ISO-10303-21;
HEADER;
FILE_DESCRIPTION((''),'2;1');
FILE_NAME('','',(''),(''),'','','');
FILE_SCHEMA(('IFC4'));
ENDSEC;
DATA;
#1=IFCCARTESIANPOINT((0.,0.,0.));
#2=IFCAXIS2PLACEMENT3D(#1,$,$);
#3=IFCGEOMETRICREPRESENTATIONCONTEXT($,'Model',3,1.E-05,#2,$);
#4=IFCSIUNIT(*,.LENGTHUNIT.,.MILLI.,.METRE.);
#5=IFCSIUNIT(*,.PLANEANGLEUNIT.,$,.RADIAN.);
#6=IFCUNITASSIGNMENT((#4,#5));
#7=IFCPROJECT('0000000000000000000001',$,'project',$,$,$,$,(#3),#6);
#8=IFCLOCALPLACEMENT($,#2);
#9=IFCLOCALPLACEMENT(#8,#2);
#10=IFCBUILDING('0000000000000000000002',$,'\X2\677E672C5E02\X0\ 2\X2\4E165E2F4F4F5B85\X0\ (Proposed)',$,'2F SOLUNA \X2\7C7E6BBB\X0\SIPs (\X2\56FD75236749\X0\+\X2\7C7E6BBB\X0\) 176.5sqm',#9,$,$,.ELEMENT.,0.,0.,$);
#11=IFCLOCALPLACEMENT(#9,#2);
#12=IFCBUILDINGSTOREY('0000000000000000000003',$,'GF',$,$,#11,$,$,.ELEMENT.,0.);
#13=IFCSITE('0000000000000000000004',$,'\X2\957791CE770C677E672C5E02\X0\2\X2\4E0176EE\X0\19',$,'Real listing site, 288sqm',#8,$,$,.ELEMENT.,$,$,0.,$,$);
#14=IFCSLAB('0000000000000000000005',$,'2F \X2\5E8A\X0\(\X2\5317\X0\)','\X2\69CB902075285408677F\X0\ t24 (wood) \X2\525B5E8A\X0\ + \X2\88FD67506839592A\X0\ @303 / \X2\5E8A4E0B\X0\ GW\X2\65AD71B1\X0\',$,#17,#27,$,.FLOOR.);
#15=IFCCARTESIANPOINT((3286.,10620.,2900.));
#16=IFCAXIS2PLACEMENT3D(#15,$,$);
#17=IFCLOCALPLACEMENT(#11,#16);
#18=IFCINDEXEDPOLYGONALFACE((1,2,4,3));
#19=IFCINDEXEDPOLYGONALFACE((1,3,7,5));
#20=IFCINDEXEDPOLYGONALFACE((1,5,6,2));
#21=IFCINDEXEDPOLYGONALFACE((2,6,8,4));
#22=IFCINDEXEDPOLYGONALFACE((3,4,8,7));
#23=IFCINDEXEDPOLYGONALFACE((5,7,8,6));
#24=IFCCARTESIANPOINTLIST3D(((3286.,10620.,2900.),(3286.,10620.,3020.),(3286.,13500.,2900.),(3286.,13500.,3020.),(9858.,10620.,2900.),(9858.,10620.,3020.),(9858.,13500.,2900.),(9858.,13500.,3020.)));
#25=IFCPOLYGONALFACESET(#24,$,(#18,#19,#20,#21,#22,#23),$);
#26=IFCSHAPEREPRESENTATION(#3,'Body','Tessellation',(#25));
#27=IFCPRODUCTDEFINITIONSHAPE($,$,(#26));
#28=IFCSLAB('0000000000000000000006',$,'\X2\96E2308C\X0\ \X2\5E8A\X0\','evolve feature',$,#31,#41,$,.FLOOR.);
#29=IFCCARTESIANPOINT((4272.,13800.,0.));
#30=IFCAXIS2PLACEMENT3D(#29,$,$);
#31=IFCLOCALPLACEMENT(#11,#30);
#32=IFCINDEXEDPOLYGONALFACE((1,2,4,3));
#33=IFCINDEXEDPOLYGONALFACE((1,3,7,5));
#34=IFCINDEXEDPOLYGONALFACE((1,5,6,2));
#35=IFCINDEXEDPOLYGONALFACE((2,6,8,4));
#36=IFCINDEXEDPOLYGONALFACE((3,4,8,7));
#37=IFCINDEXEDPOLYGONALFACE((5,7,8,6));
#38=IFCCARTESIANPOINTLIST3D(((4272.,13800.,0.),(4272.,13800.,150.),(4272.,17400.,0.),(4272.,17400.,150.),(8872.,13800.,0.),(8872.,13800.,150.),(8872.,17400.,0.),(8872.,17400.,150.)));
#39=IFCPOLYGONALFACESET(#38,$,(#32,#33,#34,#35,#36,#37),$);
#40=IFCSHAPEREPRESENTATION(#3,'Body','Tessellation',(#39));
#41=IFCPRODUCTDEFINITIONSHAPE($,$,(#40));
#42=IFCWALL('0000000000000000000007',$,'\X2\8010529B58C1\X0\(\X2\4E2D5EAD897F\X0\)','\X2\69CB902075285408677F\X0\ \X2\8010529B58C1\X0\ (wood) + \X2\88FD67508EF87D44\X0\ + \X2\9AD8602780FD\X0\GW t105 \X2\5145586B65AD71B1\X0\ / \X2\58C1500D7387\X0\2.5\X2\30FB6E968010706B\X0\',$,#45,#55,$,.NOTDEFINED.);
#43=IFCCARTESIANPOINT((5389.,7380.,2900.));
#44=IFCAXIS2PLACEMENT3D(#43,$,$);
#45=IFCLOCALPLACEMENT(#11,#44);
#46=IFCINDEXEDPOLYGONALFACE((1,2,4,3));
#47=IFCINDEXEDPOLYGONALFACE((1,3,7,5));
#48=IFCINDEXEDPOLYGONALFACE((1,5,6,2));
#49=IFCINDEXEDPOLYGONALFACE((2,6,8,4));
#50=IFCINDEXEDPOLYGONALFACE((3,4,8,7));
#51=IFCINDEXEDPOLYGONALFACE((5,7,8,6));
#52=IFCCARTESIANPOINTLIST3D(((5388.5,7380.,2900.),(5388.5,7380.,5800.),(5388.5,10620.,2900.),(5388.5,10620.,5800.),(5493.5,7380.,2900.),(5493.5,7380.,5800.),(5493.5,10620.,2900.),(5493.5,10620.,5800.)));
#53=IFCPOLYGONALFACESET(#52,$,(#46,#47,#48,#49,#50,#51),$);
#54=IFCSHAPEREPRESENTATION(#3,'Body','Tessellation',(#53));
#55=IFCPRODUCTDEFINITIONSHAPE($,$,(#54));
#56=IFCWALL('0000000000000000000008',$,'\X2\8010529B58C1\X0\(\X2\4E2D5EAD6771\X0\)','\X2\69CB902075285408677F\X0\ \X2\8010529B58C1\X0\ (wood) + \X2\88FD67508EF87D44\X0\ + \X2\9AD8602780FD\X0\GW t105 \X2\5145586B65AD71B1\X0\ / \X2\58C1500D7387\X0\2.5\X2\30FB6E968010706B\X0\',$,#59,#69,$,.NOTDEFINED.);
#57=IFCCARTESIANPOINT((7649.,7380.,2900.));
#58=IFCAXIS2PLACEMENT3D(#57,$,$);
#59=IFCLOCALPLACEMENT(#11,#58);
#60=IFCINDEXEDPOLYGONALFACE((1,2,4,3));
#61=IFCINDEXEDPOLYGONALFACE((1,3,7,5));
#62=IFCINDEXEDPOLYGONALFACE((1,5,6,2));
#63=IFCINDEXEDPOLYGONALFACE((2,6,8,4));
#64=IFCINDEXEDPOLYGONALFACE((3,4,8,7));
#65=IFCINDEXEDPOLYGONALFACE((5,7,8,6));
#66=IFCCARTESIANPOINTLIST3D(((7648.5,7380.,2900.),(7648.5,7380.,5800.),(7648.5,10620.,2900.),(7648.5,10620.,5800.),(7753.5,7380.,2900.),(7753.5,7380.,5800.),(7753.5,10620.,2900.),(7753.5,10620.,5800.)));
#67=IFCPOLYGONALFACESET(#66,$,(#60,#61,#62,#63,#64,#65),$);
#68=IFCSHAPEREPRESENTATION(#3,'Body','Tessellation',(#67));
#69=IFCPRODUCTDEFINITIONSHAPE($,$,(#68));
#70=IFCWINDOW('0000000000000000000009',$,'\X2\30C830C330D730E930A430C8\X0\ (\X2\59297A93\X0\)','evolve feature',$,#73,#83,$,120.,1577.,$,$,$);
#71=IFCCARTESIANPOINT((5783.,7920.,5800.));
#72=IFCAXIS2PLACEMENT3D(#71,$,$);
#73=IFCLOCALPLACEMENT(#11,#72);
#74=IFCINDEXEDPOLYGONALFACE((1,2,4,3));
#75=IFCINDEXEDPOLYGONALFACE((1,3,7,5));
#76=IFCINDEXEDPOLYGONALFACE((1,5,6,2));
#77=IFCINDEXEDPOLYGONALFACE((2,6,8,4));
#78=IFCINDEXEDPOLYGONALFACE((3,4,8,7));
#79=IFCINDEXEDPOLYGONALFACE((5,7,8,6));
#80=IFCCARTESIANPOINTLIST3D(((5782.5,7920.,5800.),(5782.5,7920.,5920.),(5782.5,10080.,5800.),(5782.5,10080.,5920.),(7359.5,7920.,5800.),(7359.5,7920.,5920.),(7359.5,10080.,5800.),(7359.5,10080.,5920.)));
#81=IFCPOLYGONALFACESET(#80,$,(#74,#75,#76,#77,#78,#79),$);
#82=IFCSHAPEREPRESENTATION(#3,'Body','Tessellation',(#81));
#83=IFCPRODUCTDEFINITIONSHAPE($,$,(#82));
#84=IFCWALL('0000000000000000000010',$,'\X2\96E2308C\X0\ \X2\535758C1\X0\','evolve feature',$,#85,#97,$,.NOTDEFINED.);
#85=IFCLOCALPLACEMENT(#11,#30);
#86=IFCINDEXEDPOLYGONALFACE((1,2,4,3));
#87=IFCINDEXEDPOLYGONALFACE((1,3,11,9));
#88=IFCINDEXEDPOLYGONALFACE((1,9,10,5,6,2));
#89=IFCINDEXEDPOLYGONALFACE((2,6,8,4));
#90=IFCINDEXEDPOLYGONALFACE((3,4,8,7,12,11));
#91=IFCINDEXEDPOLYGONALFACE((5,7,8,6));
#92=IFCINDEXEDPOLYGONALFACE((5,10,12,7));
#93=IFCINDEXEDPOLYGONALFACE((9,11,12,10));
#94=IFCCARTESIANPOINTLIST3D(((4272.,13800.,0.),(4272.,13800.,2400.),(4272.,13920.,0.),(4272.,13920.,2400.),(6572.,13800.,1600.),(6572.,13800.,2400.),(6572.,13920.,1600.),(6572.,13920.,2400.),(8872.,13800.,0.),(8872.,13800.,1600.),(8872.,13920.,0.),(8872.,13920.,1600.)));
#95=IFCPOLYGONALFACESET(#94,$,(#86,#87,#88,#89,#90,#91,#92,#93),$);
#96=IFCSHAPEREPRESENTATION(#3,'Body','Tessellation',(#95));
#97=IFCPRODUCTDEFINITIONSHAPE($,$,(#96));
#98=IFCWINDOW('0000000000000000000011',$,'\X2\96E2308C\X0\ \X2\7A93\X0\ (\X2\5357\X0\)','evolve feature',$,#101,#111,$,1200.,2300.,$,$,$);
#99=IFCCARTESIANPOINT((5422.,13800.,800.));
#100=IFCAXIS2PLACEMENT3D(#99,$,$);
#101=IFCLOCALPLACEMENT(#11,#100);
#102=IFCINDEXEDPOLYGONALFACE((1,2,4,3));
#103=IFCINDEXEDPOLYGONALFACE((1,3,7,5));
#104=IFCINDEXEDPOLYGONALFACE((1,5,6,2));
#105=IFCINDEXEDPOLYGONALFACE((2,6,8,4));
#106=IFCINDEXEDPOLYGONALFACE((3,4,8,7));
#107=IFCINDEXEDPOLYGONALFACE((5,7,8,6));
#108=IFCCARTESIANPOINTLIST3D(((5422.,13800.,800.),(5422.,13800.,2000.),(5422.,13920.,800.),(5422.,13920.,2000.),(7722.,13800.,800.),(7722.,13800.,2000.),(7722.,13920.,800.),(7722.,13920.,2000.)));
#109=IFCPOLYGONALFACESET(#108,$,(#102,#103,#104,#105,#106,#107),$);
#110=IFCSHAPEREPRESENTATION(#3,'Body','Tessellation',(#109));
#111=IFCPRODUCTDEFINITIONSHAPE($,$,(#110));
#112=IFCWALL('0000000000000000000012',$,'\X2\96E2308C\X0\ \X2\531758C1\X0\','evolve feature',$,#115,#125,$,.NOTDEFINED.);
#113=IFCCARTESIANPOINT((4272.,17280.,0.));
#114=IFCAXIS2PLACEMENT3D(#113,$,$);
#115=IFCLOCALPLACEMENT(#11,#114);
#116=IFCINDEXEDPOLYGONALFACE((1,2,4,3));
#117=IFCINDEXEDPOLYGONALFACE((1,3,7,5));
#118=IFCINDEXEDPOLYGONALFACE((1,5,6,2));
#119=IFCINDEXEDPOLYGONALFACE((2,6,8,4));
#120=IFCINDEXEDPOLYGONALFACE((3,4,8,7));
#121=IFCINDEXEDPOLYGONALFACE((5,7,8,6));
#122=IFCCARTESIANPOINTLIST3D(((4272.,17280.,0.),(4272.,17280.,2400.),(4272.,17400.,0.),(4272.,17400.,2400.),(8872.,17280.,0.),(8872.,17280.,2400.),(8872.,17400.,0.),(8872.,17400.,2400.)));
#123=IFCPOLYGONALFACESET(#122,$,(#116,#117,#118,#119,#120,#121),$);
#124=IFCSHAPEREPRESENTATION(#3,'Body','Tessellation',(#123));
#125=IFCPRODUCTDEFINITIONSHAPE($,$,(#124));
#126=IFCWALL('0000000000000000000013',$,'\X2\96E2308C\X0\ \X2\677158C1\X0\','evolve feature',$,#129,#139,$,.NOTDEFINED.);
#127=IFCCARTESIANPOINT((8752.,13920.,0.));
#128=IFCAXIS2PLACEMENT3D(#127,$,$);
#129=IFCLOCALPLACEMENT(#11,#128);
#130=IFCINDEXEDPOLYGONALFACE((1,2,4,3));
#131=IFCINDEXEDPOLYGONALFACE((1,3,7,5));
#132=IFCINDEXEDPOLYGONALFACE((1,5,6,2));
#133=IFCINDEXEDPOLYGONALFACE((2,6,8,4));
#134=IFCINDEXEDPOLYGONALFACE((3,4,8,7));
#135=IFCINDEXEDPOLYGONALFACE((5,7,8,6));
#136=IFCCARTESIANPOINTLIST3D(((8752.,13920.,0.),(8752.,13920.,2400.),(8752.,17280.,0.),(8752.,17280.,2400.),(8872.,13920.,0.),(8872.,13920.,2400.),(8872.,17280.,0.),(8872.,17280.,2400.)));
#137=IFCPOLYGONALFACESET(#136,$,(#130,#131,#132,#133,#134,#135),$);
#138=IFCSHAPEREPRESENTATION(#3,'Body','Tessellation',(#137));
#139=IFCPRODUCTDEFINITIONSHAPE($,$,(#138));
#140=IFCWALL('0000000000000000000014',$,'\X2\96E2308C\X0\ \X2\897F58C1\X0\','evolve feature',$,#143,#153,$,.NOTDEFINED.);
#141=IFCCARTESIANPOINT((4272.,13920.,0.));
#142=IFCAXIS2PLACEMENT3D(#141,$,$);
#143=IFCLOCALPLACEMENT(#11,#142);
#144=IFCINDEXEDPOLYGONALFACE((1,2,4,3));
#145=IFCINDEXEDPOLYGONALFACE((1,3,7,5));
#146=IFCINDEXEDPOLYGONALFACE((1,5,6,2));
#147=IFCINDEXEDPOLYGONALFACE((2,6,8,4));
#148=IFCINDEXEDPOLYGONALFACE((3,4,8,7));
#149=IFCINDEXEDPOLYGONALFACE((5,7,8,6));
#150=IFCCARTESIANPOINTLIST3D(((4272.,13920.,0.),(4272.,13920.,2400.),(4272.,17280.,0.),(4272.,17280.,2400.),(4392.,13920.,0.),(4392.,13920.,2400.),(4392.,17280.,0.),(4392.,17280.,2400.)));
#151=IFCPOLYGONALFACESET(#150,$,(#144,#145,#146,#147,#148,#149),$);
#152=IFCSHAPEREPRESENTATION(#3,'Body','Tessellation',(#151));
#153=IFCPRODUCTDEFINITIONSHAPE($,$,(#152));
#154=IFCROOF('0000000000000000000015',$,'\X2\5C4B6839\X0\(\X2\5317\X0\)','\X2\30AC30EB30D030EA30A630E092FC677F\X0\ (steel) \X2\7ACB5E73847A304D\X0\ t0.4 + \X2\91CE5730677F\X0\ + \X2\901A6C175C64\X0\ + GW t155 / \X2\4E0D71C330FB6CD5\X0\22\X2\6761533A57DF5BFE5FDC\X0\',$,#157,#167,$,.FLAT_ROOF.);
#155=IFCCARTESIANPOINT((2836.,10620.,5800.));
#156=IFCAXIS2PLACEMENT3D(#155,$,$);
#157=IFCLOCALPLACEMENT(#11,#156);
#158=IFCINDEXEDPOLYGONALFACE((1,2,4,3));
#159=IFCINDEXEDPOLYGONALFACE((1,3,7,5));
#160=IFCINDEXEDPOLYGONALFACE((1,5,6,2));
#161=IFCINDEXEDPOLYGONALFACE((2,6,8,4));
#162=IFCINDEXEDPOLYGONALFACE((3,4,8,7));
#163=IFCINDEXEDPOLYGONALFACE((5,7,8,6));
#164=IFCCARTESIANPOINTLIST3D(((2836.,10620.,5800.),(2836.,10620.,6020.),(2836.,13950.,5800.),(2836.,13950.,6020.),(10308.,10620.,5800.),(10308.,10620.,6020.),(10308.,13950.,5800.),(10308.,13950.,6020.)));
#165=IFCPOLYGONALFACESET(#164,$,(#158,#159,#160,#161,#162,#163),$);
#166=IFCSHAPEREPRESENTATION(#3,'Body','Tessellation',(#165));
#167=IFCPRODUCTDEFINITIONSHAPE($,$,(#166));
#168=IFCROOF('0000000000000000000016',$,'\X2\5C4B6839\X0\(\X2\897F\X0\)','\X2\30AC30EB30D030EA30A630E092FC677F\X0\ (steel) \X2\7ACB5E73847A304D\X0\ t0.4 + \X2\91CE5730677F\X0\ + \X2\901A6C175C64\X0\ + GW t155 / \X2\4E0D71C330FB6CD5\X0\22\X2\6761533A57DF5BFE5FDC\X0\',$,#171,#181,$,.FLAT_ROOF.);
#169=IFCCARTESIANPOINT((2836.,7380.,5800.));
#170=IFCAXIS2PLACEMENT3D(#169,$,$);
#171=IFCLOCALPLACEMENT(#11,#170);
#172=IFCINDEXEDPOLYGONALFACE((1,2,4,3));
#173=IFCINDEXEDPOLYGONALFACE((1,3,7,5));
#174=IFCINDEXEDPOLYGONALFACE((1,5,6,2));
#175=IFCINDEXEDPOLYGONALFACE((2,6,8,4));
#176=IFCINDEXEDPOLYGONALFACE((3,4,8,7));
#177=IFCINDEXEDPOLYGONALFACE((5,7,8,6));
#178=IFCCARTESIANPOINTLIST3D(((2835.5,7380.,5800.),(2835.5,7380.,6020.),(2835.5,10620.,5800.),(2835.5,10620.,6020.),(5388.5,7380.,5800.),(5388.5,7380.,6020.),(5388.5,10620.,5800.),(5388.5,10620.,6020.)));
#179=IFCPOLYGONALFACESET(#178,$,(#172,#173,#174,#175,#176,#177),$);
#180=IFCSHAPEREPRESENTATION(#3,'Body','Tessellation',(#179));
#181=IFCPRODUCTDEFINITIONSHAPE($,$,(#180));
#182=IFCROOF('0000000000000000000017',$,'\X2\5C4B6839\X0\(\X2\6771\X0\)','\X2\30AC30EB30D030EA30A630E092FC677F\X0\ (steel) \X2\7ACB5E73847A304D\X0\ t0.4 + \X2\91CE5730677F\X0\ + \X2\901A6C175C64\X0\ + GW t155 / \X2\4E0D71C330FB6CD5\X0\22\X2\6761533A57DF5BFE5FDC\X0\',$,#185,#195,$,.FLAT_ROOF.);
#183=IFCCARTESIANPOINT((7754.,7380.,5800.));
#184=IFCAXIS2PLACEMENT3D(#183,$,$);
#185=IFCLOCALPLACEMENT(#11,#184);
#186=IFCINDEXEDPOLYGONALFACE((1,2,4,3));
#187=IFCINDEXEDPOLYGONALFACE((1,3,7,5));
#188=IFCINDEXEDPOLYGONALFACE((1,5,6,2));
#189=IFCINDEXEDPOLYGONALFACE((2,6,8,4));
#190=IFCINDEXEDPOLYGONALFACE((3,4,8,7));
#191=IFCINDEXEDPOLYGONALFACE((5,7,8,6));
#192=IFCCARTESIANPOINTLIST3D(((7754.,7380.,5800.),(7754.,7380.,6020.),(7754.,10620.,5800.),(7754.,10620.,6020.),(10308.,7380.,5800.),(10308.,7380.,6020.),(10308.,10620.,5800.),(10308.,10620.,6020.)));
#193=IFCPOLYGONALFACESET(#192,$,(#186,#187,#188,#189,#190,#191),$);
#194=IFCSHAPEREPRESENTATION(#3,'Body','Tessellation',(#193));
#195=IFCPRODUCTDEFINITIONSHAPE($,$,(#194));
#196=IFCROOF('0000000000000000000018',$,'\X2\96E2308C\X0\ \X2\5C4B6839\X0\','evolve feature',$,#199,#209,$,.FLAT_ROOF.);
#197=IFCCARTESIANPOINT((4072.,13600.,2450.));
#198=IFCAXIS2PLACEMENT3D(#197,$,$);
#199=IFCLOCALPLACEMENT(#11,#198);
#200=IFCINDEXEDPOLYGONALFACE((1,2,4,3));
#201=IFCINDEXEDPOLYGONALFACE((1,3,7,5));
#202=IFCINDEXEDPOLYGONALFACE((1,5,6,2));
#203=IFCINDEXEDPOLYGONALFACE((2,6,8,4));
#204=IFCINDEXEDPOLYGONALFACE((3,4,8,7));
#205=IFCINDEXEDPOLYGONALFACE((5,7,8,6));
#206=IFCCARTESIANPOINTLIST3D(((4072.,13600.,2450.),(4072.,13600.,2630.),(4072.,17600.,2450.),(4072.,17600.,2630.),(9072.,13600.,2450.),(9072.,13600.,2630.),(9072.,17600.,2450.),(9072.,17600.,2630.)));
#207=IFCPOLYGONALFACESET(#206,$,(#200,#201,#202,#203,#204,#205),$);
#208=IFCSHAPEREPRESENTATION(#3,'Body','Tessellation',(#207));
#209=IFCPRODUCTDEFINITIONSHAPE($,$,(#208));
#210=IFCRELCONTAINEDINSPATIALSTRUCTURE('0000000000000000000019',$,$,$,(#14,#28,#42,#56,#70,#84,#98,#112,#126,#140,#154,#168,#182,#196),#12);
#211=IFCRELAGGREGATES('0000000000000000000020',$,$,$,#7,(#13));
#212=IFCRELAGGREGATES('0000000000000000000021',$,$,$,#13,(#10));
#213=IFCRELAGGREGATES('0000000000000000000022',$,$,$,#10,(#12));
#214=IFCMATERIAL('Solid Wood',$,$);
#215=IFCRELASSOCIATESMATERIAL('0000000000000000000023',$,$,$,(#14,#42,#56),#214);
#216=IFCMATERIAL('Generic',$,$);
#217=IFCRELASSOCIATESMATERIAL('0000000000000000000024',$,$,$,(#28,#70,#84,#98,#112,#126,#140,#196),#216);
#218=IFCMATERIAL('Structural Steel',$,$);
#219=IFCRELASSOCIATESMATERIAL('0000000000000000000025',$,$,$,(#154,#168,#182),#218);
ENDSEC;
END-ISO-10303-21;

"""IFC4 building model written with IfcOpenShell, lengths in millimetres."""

from ifc_helpers import new_model, si_unit, frame, frame_2d, origin, place, context, project, spatial, rectangle, extrude, material, element, fill, save


model = new_model("IFC4")

# Units and contexts
model_context = context("Model", 3, precision=1e-05, world=origin())
ifc_project = project(units=[si_unit("LENGTHUNIT", "METRE", prefix="MILLI"), si_unit("PLANEANGLEUNIT", "RADIAN")], contexts=[model_context])

# Site, building, storey
site_placement = place(None, origin())
site = spatial("IfcSite", under=ifc_project, at=site_placement, Name="長野県松本市2丁目19", ObjectType="Real listing site, 288sqm", CompositionType="ELEMENT", RefElevation=0.0)
building_placement = place(site_placement, origin())
building = spatial("IfcBuilding", under=site, at=building_placement, Name="松本市 2世帯住宅 (Proposed)", ObjectType="2F SOLUNA 籾殻SIPs (国産杉+籾殻) 176.5sqm", CompositionType="ELEMENT", ElevationOfRefHeight=0.0, ElevationOfTerrain=0.0)
storey_placement = place(building_placement, origin())
storey = spatial("IfcBuildingStorey", under=building, at=storey_placement, Name="GF", CompositionType="ELEMENT", Elevation=0.0)

# Slabs
ifc_material_1 = material(Name="Solid Wood")
slab_1_placement = place(storey_placement, frame((3286.0, 10620.0, 2900.0)))
element("IfcSlab", 1, at=slab_1_placement, inside=storey, material=ifc_material_1, Name="2F 床(北)", Description="構造用合板 t24 (wood) 剛床 + 製材根太 @303 / 床下 GW断熱", PredefinedType="FLOOR", context=model_context, shape_type="SweptSolid", body=[
    extrude(rectangle(XDim=6572.0, YDim=2880.0, at=frame_2d((3286.0, 1440.0))), frame((3286.0, 10620.0, 2900.0)), (0.0, 0.0, 1.0), 120.0),
])
ifc_material_2 = material(Name="Generic")
slab_2_placement = place(storey_placement, frame((4272.0, 13800.0, 0.0)))
element("IfcSlab", 2, at=slab_2_placement, inside=storey, material=ifc_material_2, Name="離れ 床", Description="evolve feature", PredefinedType="FLOOR", context=model_context, shape_type="SweptSolid", body=[
    extrude(rectangle(XDim=4600.0, YDim=3600.0, at=frame_2d((2300.0, 1800.0))), frame((4272.0, 13800.0, 0.0)), (0.0, 0.0, 1.0), 150.0),
])

# Walls
wall_1_placement = place(storey_placement, frame((5389.0, 7380.0, 2900.0)))
element("IfcWall", 3, at=wall_1_placement, inside=storey, material=ifc_material_1, Name="耐力壁(中庭西)", Description="構造用合板 耐力壁 (wood) + 製材軸組 + 高性能GW t105 充填断熱 / 壁倍率2.5・準耐火", PredefinedType="NOTDEFINED", context=model_context, shape_type="SweptSolid", body=[
    extrude(rectangle(XDim=105.0, YDim=3240.0, at=frame_2d((52.0, 1620.0))), frame((5389.0, 7380.0, 2900.0)), (0.0, 0.0, 1.0), 2900.0),
])
wall_2_placement = place(storey_placement, frame((7649.0, 7380.0, 2900.0)))
element("IfcWall", 4, at=wall_2_placement, inside=storey, material=ifc_material_1, Name="耐力壁(中庭東)", Description="構造用合板 耐力壁 (wood) + 製材軸組 + 高性能GW t105 充填断熱 / 壁倍率2.5・準耐火", PredefinedType="NOTDEFINED", context=model_context, shape_type="SweptSolid", body=[
    extrude(rectangle(XDim=105.0, YDim=3240.0, at=frame_2d((52.0, 1620.0))), frame((7649.0, 7380.0, 2900.0)), (0.0, 0.0, 1.0), 2900.0),
])

# Window
window_1_placement = place(storey_placement, frame((5783.0, 7920.0, 5800.0)))
element("IfcWindow", 5, at=window_1_placement, inside=storey, material=ifc_material_2, Name="トップライト (天窓)", Description="evolve feature", OverallHeight=120.0, OverallWidth=1577.0, context=model_context, shape_type="SweptSolid", body=[
    extrude(rectangle(XDim=1577.0, YDim=2160.0, at=frame_2d((788.0, 1080.0))), frame((5783.0, 7920.0, 5800.0)), (0.0, 0.0, 1.0), 120.0),
])

# Wall, opening, window
wall_3_placement = place(storey_placement, frame((4272.0, 13800.0, 0.0)))
wall_3 = element("IfcWall", 6, at=wall_3_placement, inside=storey, material=ifc_material_2, Name="離れ 南壁", Description="evolve feature", PredefinedType="NOTDEFINED", context=model_context, shape_type="SweptSolid", body=[
    extrude(rectangle(XDim=4600.0, YDim=120.0, at=frame_2d((2300.0, 60.0))), frame((4272.0, 13800.0, 0.0)), (0.0, 0.0, 1.0), 2400.0),
])
opening_1_placement = place(storey_placement, frame((5422.0, 13800.0, 800.0)))
opening_1 = element("IfcOpeningElement", 7, at=opening_1_placement, cuts=wall_3, PredefinedType="NOTDEFINED", context=model_context, shape_type="SweptSolid", body=[
    extrude(rectangle(XDim=2300.0, YDim=120.0, at=frame_2d((1150.0, 60.0))), frame((5422.0, 13800.0, 800.0)), (0.0, 0.0, 1.0), 1200.0),
])
window_2_placement = place(storey_placement, frame((5422.0, 13800.0, 800.0)))
window_2 = element("IfcWindow", 8, at=window_2_placement, inside=storey, material=ifc_material_2, Name="離れ 窓 (南)", Description="evolve feature", OverallHeight=1200.0, OverallWidth=2300.0, context=model_context, shape_type="SweptSolid", body=[
    extrude(rectangle(XDim=2300.0, YDim=120.0, at=frame_2d((1150.0, 60.0))), frame((5422.0, 13800.0, 800.0)), (0.0, 0.0, 1.0), 1200.0),
])
fill(opening_1, window_2)

# Walls
wall_4_placement = place(storey_placement, frame((4272.0, 17280.0, 0.0)))
element("IfcWall", 9, at=wall_4_placement, inside=storey, material=ifc_material_2, Name="離れ 北壁", Description="evolve feature", PredefinedType="NOTDEFINED", context=model_context, shape_type="SweptSolid", body=[
    extrude(rectangle(XDim=4600.0, YDim=120.0, at=frame_2d((2300.0, 60.0))), frame((4272.0, 17280.0, 0.0)), (0.0, 0.0, 1.0), 2400.0),
])
wall_5_placement = place(storey_placement, frame((8752.0, 13920.0, 0.0)))
element("IfcWall", 10, at=wall_5_placement, inside=storey, material=ifc_material_2, Name="離れ 東壁", Description="evolve feature", PredefinedType="NOTDEFINED", context=model_context, shape_type="SweptSolid", body=[
    extrude(rectangle(XDim=120.0, YDim=3360.0, at=frame_2d((60.0, 1680.0))), frame((8752.0, 13920.0, 0.0)), (0.0, 0.0, 1.0), 2400.0),
])
wall_6_placement = place(storey_placement, frame((4272.0, 13920.0, 0.0)))
element("IfcWall", 11, at=wall_6_placement, inside=storey, material=ifc_material_2, Name="離れ 西壁", Description="evolve feature", PredefinedType="NOTDEFINED", context=model_context, shape_type="SweptSolid", body=[
    extrude(rectangle(XDim=120.0, YDim=3360.0, at=frame_2d((60.0, 1680.0))), frame((4272.0, 13920.0, 0.0)), (0.0, 0.0, 1.0), 2400.0),
])

# Roofs
ifc_material_3 = material(Name="Structural Steel")
for number, where, name in (
    (12, (2836.0, 10620.0, 5800.0), "屋根(北)"),
):
    element("IfcRoof", number, at=place(storey_placement, frame(where)), inside=storey, material=ifc_material_3, Name=name, Description="ガルバリウム鋼板 (steel) 立平葺き t0.4 + 野地板 + 通気層 + GW t155 / 不燃・法22条区域対応", PredefinedType="FLAT_ROOF", context=model_context, shape_type="SweptSolid", body=[
        extrude(rectangle(XDim=7472.0, YDim=3330.0, at=frame_2d((3736.0, 1665.0))), frame((2836.0, 10620.0, 5800.0)), (0.0, 0.0, 1.0), 220.0),
    ])
roof_1_placement = place(storey_placement, frame((2836.0, 7380.0, 5800.0)))
element("IfcRoof", 13, at=roof_1_placement, inside=storey, material=ifc_material_3, Name="屋根(西)", Description="ガルバリウム鋼板 (steel) 立平葺き t0.4 + 野地板 + 通気層 + GW t155 / 不燃・法22条区域対応", PredefinedType="FLAT_ROOF", context=model_context, shape_type="SweptSolid", body=[
    extrude(rectangle(XDim=2553.0, YDim=3240.0, at=frame_2d((1276.0, 1620.0))), frame((2836.0, 7380.0, 5800.0)), (0.0, 0.0, 1.0), 220.0),
])
roof_2_placement = place(storey_placement, frame((7754.0, 7380.0, 5800.0)))
element("IfcRoof", 14, at=roof_2_placement, inside=storey, material=ifc_material_3, Name="屋根(東)", Description="ガルバリウム鋼板 (steel) 立平葺き t0.4 + 野地板 + 通気層 + GW t155 / 不燃・法22条区域対応", PredefinedType="FLAT_ROOF", context=model_context, shape_type="SweptSolid", body=[
    extrude(rectangle(XDim=2554.0, YDim=3240.0, at=frame_2d((1277.0, 1620.0))), frame((7754.0, 7380.0, 5800.0)), (0.0, 0.0, 1.0), 220.0),
])
roof_3_placement = place(storey_placement, frame((4072.0, 13600.0, 2450.0)))
element("IfcRoof", 15, at=roof_3_placement, inside=storey, material=ifc_material_2, Name="離れ 屋根", Description="evolve feature", PredefinedType="FLAT_ROOF", context=model_context, shape_type="SweptSolid", body=[
    extrude(rectangle(XDim=5000.0, YDim=4000.0, at=frame_2d((2500.0, 2000.0))), frame((4072.0, 13600.0, 2450.0)), (0.0, 0.0, 1.0), 180.0),
])

save(model, "model.ifc")
